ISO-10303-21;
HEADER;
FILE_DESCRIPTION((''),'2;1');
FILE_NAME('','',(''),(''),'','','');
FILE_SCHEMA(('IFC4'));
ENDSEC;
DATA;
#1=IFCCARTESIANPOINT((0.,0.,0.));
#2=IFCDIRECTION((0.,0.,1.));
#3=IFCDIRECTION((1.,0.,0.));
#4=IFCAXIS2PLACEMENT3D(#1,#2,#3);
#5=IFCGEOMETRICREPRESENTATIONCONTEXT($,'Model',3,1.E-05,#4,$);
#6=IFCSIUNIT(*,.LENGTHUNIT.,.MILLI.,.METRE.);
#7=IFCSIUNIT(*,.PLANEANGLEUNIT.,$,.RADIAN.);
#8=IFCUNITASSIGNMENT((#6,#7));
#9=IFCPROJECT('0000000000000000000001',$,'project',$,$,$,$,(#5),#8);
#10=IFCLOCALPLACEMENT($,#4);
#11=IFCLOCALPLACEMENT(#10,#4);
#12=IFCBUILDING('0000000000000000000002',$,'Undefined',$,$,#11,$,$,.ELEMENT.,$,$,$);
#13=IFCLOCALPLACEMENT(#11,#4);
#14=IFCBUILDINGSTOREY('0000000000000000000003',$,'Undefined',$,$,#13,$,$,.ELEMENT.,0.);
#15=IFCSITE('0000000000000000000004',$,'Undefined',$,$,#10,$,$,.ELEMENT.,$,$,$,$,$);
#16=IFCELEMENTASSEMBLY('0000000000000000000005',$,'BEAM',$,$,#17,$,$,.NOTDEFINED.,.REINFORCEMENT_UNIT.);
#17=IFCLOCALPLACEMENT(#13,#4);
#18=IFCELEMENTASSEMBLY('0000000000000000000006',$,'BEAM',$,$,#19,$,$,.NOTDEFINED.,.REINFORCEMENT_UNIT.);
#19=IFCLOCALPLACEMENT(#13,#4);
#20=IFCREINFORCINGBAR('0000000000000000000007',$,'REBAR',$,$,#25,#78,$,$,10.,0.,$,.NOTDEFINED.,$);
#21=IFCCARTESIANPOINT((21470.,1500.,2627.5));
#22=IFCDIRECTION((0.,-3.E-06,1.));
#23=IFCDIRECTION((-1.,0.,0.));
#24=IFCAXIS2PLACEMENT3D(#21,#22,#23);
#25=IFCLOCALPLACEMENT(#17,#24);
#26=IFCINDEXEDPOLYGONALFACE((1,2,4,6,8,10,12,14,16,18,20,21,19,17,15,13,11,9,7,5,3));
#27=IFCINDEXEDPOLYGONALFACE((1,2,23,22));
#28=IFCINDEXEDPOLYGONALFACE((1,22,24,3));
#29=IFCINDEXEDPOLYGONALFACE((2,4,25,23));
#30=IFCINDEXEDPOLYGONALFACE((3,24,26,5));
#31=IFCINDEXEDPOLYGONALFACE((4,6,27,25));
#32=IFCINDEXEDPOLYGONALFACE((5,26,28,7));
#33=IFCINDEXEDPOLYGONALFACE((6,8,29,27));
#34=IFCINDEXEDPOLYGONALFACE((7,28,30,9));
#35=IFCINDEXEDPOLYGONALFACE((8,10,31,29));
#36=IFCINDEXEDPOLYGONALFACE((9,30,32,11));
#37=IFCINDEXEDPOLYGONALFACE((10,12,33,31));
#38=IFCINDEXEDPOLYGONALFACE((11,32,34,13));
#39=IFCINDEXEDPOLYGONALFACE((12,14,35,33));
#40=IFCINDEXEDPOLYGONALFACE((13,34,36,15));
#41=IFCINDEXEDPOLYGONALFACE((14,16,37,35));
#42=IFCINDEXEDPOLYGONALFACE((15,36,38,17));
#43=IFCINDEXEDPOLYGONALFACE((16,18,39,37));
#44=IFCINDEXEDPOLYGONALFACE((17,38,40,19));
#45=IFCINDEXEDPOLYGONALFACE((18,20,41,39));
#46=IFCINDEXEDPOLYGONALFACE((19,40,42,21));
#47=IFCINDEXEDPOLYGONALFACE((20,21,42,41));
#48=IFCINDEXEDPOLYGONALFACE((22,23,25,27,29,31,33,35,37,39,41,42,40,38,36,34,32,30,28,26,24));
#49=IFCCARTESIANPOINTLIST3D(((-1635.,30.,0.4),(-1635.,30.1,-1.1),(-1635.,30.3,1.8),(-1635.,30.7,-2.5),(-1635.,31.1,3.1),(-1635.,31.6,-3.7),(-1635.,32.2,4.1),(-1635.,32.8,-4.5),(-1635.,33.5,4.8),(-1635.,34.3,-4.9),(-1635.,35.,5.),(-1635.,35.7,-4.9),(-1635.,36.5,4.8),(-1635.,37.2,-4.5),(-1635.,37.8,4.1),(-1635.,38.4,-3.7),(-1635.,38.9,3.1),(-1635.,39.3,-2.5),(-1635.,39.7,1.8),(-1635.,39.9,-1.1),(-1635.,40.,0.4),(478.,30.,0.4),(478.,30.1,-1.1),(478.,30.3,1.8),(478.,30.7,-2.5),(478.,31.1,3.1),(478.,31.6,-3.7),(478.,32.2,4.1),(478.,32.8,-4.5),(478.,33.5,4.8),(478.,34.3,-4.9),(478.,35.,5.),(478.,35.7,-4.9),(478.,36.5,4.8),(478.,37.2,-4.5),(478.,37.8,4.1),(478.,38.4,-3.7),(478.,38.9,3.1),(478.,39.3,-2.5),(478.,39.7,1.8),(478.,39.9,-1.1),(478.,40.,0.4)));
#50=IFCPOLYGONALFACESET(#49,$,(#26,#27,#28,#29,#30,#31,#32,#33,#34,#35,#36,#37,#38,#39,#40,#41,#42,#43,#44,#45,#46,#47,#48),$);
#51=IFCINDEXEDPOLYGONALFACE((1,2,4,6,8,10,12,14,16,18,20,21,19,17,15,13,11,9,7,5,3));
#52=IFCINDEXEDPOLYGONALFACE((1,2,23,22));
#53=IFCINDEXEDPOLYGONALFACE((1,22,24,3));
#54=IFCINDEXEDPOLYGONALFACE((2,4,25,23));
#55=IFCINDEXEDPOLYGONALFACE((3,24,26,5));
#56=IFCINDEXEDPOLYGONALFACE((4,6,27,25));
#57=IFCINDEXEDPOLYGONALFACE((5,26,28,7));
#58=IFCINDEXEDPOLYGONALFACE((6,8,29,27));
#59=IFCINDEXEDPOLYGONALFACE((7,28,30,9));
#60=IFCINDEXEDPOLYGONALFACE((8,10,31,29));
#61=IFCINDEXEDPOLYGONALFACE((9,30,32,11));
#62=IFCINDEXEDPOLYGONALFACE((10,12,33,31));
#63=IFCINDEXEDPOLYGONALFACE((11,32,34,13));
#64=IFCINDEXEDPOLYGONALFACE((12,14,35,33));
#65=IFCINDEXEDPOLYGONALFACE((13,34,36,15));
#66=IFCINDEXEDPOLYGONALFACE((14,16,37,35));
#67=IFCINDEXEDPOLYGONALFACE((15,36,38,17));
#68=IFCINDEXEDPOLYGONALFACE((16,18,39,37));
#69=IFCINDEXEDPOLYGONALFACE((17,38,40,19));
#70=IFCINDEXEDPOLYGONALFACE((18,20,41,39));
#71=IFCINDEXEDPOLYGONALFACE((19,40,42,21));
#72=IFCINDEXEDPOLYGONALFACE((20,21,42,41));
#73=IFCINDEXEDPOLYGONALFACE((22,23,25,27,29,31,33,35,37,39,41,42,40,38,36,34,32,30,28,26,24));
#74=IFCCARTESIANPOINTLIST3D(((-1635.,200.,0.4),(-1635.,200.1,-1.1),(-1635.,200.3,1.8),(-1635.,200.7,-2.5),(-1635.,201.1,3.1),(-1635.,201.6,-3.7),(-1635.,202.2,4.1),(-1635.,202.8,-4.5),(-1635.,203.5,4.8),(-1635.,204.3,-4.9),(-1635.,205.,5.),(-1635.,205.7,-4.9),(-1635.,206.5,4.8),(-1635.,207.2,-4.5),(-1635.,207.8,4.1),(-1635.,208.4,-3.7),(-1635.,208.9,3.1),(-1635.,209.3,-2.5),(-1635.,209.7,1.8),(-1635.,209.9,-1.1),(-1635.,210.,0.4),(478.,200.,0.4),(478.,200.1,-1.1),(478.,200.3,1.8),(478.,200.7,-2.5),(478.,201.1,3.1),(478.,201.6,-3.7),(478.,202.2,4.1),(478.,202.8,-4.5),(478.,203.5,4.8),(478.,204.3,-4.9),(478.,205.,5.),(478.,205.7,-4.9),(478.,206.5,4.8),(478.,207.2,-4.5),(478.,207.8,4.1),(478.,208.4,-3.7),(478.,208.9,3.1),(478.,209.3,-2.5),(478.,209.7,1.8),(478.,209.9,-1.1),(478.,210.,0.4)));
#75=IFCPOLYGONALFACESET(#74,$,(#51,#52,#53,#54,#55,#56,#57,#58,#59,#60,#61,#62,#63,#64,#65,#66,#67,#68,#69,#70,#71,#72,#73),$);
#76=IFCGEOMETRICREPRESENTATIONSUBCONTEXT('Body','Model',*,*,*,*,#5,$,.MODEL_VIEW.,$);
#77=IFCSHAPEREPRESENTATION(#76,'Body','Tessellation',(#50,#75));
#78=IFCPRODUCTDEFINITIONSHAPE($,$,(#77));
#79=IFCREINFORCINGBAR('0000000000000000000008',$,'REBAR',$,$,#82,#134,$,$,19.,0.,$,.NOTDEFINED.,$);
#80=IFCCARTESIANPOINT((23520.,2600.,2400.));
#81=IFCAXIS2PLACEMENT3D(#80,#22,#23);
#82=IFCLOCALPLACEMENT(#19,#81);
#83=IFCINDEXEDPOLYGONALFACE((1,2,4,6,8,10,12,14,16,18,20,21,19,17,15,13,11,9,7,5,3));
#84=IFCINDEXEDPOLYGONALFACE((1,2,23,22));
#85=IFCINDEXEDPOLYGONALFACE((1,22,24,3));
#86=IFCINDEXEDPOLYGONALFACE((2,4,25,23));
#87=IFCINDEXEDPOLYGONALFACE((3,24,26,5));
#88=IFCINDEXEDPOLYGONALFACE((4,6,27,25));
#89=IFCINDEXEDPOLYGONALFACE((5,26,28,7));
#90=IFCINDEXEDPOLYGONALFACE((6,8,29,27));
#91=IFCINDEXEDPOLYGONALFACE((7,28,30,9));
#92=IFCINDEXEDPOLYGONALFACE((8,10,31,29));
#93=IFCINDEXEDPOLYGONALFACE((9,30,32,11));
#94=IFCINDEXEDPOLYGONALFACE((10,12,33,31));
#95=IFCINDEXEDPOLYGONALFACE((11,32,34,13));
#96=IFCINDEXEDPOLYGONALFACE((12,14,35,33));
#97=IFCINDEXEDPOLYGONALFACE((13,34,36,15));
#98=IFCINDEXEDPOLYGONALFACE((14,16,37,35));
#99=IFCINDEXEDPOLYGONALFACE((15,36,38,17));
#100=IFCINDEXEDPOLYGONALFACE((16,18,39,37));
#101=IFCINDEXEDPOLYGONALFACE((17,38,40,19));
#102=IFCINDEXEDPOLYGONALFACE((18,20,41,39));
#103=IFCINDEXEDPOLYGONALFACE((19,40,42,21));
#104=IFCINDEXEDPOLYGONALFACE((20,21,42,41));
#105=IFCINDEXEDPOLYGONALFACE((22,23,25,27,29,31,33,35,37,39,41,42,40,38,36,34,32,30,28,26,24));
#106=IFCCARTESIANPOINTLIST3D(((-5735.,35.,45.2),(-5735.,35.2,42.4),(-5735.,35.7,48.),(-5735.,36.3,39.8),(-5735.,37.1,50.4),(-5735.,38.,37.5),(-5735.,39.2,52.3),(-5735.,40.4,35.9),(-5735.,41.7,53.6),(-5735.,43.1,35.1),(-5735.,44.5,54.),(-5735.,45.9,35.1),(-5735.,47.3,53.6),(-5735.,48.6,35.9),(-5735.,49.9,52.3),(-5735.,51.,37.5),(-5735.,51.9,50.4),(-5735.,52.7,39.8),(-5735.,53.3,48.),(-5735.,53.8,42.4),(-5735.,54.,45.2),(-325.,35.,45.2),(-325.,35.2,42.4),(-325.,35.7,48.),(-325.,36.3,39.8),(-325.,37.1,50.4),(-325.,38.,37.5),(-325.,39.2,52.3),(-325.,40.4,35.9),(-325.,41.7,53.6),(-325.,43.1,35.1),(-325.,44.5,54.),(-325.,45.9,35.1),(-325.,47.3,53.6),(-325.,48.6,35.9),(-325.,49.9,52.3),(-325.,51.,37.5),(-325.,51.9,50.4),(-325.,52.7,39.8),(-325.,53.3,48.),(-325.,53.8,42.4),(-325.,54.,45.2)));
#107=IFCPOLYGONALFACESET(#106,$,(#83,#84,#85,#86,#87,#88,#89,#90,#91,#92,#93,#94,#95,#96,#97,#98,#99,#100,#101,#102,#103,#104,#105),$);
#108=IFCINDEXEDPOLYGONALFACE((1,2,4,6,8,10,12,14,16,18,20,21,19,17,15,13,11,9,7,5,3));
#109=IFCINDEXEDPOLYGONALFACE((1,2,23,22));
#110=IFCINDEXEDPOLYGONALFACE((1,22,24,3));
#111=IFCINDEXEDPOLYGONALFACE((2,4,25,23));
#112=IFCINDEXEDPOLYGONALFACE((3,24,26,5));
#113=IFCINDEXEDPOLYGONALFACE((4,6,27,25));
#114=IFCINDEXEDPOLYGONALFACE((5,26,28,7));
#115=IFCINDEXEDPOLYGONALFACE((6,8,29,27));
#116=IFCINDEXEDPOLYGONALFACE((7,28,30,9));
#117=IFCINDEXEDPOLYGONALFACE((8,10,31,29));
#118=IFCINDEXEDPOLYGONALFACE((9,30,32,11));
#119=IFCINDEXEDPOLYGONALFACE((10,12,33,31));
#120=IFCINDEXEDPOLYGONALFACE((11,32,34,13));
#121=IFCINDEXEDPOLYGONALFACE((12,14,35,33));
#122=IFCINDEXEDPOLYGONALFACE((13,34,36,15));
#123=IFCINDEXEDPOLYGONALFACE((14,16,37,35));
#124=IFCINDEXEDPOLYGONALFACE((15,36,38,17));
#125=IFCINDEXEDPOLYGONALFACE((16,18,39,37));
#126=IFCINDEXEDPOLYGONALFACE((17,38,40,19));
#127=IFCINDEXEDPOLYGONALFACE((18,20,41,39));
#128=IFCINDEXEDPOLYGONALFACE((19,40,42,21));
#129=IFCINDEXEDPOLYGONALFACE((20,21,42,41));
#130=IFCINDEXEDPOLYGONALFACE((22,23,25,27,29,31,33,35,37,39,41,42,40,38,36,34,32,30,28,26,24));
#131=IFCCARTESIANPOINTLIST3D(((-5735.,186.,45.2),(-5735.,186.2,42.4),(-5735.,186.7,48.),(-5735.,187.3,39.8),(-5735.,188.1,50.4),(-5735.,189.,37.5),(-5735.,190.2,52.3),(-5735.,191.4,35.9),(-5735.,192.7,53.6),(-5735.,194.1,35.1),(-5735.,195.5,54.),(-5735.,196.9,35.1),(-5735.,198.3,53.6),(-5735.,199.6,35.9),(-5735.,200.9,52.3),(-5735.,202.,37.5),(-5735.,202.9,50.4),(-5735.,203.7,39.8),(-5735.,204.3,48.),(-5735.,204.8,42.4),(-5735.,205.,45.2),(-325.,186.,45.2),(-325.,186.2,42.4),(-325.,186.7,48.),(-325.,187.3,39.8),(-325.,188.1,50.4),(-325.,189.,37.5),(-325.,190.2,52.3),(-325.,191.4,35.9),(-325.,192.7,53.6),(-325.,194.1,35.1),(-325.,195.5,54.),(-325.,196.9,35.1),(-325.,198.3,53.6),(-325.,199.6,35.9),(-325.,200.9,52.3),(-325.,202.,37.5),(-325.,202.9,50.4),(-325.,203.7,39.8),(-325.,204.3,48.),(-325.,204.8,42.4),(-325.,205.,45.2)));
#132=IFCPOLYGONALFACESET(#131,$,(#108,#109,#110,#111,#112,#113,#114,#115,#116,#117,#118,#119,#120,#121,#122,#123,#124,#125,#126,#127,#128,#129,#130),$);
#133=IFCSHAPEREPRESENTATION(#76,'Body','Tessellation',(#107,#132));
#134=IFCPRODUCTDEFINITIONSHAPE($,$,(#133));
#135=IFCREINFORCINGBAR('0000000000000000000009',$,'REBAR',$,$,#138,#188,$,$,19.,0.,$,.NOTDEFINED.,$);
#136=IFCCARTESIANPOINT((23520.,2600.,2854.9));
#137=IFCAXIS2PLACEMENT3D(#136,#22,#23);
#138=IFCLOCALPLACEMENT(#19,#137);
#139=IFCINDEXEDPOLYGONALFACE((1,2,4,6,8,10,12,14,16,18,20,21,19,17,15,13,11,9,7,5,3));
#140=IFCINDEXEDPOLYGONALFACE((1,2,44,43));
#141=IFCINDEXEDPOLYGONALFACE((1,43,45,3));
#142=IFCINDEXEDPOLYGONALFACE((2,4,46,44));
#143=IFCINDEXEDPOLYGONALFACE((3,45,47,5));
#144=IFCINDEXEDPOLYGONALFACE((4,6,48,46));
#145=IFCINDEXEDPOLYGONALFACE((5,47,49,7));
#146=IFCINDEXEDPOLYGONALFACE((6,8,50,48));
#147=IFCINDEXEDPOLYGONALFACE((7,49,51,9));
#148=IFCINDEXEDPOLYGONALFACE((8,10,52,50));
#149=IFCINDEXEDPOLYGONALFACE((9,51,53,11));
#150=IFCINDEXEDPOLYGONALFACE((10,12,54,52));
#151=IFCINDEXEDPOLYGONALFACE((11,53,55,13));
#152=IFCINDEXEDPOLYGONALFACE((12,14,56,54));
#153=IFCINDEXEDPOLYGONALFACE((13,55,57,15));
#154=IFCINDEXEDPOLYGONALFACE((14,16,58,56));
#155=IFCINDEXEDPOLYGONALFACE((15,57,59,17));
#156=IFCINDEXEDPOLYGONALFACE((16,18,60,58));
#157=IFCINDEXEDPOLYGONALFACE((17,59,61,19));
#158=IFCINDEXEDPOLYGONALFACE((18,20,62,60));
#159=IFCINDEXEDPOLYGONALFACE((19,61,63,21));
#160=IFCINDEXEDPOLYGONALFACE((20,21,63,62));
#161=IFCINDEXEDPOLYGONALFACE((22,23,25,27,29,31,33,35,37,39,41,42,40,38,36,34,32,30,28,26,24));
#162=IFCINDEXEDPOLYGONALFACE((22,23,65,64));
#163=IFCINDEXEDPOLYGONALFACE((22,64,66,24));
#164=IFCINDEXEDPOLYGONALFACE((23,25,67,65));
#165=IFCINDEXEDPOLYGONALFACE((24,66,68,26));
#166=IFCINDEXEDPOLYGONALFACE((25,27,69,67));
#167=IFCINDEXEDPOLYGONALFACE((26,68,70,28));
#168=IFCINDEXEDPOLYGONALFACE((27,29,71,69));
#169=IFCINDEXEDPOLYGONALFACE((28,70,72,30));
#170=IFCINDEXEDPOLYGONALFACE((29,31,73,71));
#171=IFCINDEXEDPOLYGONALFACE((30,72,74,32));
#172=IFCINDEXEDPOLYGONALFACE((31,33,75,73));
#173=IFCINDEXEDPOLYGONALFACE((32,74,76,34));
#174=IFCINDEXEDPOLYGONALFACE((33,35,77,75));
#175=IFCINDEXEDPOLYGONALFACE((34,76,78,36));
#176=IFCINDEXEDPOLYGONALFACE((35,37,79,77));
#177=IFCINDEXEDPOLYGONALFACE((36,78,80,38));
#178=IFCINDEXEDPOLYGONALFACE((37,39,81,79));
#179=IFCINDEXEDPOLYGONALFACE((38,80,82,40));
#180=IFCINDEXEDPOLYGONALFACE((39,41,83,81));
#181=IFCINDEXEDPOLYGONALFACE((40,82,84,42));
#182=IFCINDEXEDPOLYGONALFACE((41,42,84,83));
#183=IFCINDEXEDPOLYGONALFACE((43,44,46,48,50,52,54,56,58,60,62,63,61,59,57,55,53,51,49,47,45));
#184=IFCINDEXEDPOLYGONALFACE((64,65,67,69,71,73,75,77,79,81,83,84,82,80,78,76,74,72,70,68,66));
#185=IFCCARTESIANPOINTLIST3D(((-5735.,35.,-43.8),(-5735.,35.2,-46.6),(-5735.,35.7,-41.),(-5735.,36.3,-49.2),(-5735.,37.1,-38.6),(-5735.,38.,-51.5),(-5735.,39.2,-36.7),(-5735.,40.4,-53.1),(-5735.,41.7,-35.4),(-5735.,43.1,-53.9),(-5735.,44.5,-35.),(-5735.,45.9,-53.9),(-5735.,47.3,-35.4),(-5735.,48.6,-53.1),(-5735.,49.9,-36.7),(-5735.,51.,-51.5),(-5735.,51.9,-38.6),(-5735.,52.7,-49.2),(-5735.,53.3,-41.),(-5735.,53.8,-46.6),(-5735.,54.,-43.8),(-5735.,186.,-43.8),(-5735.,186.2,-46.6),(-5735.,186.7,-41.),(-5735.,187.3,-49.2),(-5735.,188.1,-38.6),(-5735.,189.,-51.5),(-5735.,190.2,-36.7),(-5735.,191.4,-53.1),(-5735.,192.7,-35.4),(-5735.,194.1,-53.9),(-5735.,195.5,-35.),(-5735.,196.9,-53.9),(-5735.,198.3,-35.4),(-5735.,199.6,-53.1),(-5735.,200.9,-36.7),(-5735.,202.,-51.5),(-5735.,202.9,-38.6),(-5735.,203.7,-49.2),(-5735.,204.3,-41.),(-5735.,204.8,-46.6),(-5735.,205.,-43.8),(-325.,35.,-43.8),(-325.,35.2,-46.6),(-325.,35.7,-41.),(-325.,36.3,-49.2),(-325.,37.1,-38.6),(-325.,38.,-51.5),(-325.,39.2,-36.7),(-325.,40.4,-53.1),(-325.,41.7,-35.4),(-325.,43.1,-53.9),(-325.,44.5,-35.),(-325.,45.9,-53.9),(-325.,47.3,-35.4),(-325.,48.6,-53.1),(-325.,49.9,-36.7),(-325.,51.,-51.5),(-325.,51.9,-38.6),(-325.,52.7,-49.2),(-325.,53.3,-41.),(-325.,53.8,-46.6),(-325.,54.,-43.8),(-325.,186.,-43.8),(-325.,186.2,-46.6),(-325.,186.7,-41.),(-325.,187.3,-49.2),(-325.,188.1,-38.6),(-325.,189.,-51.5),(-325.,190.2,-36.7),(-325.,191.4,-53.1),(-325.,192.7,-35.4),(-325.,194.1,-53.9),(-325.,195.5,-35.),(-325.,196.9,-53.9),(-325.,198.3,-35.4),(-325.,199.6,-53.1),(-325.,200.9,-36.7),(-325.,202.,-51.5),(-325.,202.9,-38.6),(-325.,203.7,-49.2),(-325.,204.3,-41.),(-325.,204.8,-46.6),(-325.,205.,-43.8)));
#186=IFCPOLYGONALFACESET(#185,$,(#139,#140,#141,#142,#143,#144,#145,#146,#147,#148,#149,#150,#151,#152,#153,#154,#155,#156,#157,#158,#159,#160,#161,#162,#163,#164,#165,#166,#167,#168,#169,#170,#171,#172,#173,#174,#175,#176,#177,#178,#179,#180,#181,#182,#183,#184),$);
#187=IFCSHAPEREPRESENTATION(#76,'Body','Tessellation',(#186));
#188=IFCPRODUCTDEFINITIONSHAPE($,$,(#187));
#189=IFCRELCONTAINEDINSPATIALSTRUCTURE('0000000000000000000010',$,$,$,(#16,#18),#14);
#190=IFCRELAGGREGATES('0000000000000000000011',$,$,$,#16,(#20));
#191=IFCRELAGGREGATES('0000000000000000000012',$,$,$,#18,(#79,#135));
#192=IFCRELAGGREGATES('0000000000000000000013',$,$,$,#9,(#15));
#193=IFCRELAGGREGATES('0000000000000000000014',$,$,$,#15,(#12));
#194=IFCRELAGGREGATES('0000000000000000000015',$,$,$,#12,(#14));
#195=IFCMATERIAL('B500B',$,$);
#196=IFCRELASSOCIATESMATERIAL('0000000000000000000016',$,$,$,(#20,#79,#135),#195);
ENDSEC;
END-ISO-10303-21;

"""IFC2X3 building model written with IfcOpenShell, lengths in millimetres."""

from ifc_helpers import new_model, entity, si_unit, frame, origin_with_axes, place, context, subcontext, project, spatial, source, transform, mapped, material, element, aggregate, save


model = new_model("IFC2X3")

# Units and contexts
model_context = context("Model", 3, precision=1e-05, world=origin_with_axes())
body_context = subcontext(model_context, "Body", "Model", "MODEL_VIEW")
ifc_project = project(units=[si_unit("LENGTHUNIT", "METRE", prefix="MILLI"), si_unit("PLANEANGLEUNIT", "RADIAN")], contexts=[model_context])

# Site, building, storey
site_placement = place(None, origin_with_axes())
site = spatial("IfcSite", under=ifc_project, at=site_placement, Name="Undefined", CompositionType="ELEMENT")
building_placement = place(site_placement, origin_with_axes())
building = spatial("IfcBuilding", under=site, at=building_placement, Name="Undefined", CompositionType="ELEMENT")
storey_placement = place(building_placement, origin_with_axes())
storey = spatial("IfcBuildingStorey", under=building, at=storey_placement, Name="Undefined", CompositionType="ELEMENT", Elevation=0.0)

# Element assembly
assembly_1_placement = place(storey_placement, origin_with_axes())
assembly_1 = element("IfcElementAssembly", 1, at=assembly_1_placement, inside=storey, Name="BEAM", AssemblyPlace="NOTDEFINED", PredefinedType="REINFORCEMENT_UNIT")

# Element assembly
assembly_2_placement = place(storey_placement, origin_with_axes())
assembly_2 = element("IfcElementAssembly", 2, at=assembly_2_placement, inside=storey, Name="BEAM", AssemblyPlace="NOTDEFINED", PredefinedType="REINFORCEMENT_UNIT")

# Reinforcing bars
ifc_material_1 = material(Name="B500B")
shared_shape_1 = source(origin_with_axes(), body_context, "Body", "AdvancedSweptSolid", [
    entity("IfcSweptDiskSolid", entity("IfcTrimmedCurve", entity("IfcLine", entity("IfcCartesianPoint", [0.0, 0.0, 0.0]), entity("IfcVector", entity("IfcDirection", [1.0, 0.0, 0.0]), 1.0)), [entity("IfcParameterValue", 0.0)], [entity("IfcParameterValue", 2113.062834)], True, "PARAMETER"), 5.0, None, 0.0, 2113.1),
])
shared_shape_2 = source(origin_with_axes(), body_context, "Body", "AdvancedSweptSolid", [
    entity("IfcSweptDiskSolid", entity("IfcTrimmedCurve", entity("IfcLine", entity("IfcCartesianPoint", [0.0, 0.0, 0.0]), entity("IfcVector", entity("IfcDirection", [1.0, 0.0, 0.0]), 1.0)), [entity("IfcParameterValue", 0.0)], [entity("IfcParameterValue", 2113.062834)], True, "PARAMETER"), 5.0, None, 0.0, 2113.1),
])
reinforcing_bar_1_placement = place(assembly_1_placement, frame((21470.0, 1500.0, 2627.5), z_axis=(0.0, -0.000003, 1.0), x_axis=(-1.0, 0.0, 0.0)))
reinforcing_bar_1 = element("IfcReinforcingBar", 3, at=reinforcing_bar_1_placement, material=ifc_material_1, Name="REBAR", BarRole="NOTDEFINED", CrossSectionArea=0.0, NominalDiameter=10.0, context=body_context, shape_type="MappedRepresentation", body=[
    mapped(shared_shape_1, transform((-1635.0, 35.0, 0.0))),
    mapped(shared_shape_2, transform((-1635.0, 205.0, 0.0))),
])
aggregate(assembly_1, [reinforcing_bar_1])
shared_shape_3 = source(origin_with_axes(), body_context, "Body", "AdvancedSweptSolid", [
    entity("IfcSweptDiskSolid", entity("IfcTrimmedCurve", entity("IfcLine", entity("IfcCartesianPoint", [0.0, 0.0, 0.0]), entity("IfcVector", entity("IfcDirection", [1.0, 0.0, 0.0]), 1.0)), [entity("IfcParameterValue", 0.0)], [entity("IfcParameterValue", 5409.992833)], True, "PARAMETER"), 9.5, None, 0.0, 5410.0),
])
shared_shape_4 = source(origin_with_axes(), body_context, "Body", "AdvancedSweptSolid", [
    entity("IfcSweptDiskSolid", entity("IfcTrimmedCurve", entity("IfcLine", entity("IfcCartesianPoint", [0.0, 0.0, 0.0]), entity("IfcVector", entity("IfcDirection", [1.0, 0.0, 0.0]), 1.0)), [entity("IfcParameterValue", 0.0)], [entity("IfcParameterValue", 5409.992833)], True, "PARAMETER"), 9.5, None, 0.0, 5410.0),
])
reinforcing_bar_2_placement = place(assembly_2_placement, frame((23520.0, 2600.0, 2400.0), z_axis=(0.0, -0.000003, 1.0), x_axis=(-1.0, 0.0, 0.0)))
reinforcing_bar_2 = element("IfcReinforcingBar", 4, at=reinforcing_bar_2_placement, material=ifc_material_1, Name="REBAR", BarRole="NOTDEFINED", CrossSectionArea=0.0, NominalDiameter=19.0, context=body_context, shape_type="MappedRepresentation", body=[
    mapped(shared_shape_3, transform((-5735.0, 44.5, 44.5))),
    mapped(shared_shape_4, transform((-5735.0, 195.5, 44.5))),
])
shared_shape_5 = source(origin_with_axes(), body_context, "Body", "AdvancedSweptSolid", [
    entity("IfcSweptDiskSolid", entity("IfcTrimmedCurve", entity("IfcLine", entity("IfcCartesianPoint", [0.0, 0.0, 0.0]), entity("IfcVector", entity("IfcDirection", [1.0, 0.0, 0.0]), 1.0)), [entity("IfcParameterValue", 0.0)], [entity("IfcParameterValue", 5409.992833)], True, "PARAMETER"), 9.5, None, 0.0, 5410.0),
])
shared_shape_6 = source(origin_with_axes(), body_context, "Body", "AdvancedSweptSolid", [
    entity("IfcSweptDiskSolid", entity("IfcTrimmedCurve", entity("IfcLine", entity("IfcCartesianPoint", [0.0, 0.0, 0.0]), entity("IfcVector", entity("IfcDirection", [1.0, 0.0, 0.0]), 1.0)), [entity("IfcParameterValue", 0.0)], [entity("IfcParameterValue", 5409.992833)], True, "PARAMETER"), 9.5, None, 0.0, 5410.0),
])
reinforcing_bar_3_placement = place(assembly_2_placement, frame((23520.0, 2600.0, 2854.9), z_axis=(0.0, -0.000003, 1.0), x_axis=(-1.0, 0.0, 0.0)))
reinforcing_bar_3 = element("IfcReinforcingBar", 5, at=reinforcing_bar_3_placement, material=ifc_material_1, Name="REBAR", BarRole="NOTDEFINED", CrossSectionArea=0.0, NominalDiameter=19.0, context=body_context, shape_type="MappedRepresentation", body=[
    mapped(shared_shape_5, transform((-5735.0, 44.5, -44.5))),
    mapped(shared_shape_6, transform((-5735.0, 195.5, -44.5))),
])
aggregate(assembly_2, [reinforcing_bar_2, reinforcing_bar_3])

save(model, "model.ifc")
